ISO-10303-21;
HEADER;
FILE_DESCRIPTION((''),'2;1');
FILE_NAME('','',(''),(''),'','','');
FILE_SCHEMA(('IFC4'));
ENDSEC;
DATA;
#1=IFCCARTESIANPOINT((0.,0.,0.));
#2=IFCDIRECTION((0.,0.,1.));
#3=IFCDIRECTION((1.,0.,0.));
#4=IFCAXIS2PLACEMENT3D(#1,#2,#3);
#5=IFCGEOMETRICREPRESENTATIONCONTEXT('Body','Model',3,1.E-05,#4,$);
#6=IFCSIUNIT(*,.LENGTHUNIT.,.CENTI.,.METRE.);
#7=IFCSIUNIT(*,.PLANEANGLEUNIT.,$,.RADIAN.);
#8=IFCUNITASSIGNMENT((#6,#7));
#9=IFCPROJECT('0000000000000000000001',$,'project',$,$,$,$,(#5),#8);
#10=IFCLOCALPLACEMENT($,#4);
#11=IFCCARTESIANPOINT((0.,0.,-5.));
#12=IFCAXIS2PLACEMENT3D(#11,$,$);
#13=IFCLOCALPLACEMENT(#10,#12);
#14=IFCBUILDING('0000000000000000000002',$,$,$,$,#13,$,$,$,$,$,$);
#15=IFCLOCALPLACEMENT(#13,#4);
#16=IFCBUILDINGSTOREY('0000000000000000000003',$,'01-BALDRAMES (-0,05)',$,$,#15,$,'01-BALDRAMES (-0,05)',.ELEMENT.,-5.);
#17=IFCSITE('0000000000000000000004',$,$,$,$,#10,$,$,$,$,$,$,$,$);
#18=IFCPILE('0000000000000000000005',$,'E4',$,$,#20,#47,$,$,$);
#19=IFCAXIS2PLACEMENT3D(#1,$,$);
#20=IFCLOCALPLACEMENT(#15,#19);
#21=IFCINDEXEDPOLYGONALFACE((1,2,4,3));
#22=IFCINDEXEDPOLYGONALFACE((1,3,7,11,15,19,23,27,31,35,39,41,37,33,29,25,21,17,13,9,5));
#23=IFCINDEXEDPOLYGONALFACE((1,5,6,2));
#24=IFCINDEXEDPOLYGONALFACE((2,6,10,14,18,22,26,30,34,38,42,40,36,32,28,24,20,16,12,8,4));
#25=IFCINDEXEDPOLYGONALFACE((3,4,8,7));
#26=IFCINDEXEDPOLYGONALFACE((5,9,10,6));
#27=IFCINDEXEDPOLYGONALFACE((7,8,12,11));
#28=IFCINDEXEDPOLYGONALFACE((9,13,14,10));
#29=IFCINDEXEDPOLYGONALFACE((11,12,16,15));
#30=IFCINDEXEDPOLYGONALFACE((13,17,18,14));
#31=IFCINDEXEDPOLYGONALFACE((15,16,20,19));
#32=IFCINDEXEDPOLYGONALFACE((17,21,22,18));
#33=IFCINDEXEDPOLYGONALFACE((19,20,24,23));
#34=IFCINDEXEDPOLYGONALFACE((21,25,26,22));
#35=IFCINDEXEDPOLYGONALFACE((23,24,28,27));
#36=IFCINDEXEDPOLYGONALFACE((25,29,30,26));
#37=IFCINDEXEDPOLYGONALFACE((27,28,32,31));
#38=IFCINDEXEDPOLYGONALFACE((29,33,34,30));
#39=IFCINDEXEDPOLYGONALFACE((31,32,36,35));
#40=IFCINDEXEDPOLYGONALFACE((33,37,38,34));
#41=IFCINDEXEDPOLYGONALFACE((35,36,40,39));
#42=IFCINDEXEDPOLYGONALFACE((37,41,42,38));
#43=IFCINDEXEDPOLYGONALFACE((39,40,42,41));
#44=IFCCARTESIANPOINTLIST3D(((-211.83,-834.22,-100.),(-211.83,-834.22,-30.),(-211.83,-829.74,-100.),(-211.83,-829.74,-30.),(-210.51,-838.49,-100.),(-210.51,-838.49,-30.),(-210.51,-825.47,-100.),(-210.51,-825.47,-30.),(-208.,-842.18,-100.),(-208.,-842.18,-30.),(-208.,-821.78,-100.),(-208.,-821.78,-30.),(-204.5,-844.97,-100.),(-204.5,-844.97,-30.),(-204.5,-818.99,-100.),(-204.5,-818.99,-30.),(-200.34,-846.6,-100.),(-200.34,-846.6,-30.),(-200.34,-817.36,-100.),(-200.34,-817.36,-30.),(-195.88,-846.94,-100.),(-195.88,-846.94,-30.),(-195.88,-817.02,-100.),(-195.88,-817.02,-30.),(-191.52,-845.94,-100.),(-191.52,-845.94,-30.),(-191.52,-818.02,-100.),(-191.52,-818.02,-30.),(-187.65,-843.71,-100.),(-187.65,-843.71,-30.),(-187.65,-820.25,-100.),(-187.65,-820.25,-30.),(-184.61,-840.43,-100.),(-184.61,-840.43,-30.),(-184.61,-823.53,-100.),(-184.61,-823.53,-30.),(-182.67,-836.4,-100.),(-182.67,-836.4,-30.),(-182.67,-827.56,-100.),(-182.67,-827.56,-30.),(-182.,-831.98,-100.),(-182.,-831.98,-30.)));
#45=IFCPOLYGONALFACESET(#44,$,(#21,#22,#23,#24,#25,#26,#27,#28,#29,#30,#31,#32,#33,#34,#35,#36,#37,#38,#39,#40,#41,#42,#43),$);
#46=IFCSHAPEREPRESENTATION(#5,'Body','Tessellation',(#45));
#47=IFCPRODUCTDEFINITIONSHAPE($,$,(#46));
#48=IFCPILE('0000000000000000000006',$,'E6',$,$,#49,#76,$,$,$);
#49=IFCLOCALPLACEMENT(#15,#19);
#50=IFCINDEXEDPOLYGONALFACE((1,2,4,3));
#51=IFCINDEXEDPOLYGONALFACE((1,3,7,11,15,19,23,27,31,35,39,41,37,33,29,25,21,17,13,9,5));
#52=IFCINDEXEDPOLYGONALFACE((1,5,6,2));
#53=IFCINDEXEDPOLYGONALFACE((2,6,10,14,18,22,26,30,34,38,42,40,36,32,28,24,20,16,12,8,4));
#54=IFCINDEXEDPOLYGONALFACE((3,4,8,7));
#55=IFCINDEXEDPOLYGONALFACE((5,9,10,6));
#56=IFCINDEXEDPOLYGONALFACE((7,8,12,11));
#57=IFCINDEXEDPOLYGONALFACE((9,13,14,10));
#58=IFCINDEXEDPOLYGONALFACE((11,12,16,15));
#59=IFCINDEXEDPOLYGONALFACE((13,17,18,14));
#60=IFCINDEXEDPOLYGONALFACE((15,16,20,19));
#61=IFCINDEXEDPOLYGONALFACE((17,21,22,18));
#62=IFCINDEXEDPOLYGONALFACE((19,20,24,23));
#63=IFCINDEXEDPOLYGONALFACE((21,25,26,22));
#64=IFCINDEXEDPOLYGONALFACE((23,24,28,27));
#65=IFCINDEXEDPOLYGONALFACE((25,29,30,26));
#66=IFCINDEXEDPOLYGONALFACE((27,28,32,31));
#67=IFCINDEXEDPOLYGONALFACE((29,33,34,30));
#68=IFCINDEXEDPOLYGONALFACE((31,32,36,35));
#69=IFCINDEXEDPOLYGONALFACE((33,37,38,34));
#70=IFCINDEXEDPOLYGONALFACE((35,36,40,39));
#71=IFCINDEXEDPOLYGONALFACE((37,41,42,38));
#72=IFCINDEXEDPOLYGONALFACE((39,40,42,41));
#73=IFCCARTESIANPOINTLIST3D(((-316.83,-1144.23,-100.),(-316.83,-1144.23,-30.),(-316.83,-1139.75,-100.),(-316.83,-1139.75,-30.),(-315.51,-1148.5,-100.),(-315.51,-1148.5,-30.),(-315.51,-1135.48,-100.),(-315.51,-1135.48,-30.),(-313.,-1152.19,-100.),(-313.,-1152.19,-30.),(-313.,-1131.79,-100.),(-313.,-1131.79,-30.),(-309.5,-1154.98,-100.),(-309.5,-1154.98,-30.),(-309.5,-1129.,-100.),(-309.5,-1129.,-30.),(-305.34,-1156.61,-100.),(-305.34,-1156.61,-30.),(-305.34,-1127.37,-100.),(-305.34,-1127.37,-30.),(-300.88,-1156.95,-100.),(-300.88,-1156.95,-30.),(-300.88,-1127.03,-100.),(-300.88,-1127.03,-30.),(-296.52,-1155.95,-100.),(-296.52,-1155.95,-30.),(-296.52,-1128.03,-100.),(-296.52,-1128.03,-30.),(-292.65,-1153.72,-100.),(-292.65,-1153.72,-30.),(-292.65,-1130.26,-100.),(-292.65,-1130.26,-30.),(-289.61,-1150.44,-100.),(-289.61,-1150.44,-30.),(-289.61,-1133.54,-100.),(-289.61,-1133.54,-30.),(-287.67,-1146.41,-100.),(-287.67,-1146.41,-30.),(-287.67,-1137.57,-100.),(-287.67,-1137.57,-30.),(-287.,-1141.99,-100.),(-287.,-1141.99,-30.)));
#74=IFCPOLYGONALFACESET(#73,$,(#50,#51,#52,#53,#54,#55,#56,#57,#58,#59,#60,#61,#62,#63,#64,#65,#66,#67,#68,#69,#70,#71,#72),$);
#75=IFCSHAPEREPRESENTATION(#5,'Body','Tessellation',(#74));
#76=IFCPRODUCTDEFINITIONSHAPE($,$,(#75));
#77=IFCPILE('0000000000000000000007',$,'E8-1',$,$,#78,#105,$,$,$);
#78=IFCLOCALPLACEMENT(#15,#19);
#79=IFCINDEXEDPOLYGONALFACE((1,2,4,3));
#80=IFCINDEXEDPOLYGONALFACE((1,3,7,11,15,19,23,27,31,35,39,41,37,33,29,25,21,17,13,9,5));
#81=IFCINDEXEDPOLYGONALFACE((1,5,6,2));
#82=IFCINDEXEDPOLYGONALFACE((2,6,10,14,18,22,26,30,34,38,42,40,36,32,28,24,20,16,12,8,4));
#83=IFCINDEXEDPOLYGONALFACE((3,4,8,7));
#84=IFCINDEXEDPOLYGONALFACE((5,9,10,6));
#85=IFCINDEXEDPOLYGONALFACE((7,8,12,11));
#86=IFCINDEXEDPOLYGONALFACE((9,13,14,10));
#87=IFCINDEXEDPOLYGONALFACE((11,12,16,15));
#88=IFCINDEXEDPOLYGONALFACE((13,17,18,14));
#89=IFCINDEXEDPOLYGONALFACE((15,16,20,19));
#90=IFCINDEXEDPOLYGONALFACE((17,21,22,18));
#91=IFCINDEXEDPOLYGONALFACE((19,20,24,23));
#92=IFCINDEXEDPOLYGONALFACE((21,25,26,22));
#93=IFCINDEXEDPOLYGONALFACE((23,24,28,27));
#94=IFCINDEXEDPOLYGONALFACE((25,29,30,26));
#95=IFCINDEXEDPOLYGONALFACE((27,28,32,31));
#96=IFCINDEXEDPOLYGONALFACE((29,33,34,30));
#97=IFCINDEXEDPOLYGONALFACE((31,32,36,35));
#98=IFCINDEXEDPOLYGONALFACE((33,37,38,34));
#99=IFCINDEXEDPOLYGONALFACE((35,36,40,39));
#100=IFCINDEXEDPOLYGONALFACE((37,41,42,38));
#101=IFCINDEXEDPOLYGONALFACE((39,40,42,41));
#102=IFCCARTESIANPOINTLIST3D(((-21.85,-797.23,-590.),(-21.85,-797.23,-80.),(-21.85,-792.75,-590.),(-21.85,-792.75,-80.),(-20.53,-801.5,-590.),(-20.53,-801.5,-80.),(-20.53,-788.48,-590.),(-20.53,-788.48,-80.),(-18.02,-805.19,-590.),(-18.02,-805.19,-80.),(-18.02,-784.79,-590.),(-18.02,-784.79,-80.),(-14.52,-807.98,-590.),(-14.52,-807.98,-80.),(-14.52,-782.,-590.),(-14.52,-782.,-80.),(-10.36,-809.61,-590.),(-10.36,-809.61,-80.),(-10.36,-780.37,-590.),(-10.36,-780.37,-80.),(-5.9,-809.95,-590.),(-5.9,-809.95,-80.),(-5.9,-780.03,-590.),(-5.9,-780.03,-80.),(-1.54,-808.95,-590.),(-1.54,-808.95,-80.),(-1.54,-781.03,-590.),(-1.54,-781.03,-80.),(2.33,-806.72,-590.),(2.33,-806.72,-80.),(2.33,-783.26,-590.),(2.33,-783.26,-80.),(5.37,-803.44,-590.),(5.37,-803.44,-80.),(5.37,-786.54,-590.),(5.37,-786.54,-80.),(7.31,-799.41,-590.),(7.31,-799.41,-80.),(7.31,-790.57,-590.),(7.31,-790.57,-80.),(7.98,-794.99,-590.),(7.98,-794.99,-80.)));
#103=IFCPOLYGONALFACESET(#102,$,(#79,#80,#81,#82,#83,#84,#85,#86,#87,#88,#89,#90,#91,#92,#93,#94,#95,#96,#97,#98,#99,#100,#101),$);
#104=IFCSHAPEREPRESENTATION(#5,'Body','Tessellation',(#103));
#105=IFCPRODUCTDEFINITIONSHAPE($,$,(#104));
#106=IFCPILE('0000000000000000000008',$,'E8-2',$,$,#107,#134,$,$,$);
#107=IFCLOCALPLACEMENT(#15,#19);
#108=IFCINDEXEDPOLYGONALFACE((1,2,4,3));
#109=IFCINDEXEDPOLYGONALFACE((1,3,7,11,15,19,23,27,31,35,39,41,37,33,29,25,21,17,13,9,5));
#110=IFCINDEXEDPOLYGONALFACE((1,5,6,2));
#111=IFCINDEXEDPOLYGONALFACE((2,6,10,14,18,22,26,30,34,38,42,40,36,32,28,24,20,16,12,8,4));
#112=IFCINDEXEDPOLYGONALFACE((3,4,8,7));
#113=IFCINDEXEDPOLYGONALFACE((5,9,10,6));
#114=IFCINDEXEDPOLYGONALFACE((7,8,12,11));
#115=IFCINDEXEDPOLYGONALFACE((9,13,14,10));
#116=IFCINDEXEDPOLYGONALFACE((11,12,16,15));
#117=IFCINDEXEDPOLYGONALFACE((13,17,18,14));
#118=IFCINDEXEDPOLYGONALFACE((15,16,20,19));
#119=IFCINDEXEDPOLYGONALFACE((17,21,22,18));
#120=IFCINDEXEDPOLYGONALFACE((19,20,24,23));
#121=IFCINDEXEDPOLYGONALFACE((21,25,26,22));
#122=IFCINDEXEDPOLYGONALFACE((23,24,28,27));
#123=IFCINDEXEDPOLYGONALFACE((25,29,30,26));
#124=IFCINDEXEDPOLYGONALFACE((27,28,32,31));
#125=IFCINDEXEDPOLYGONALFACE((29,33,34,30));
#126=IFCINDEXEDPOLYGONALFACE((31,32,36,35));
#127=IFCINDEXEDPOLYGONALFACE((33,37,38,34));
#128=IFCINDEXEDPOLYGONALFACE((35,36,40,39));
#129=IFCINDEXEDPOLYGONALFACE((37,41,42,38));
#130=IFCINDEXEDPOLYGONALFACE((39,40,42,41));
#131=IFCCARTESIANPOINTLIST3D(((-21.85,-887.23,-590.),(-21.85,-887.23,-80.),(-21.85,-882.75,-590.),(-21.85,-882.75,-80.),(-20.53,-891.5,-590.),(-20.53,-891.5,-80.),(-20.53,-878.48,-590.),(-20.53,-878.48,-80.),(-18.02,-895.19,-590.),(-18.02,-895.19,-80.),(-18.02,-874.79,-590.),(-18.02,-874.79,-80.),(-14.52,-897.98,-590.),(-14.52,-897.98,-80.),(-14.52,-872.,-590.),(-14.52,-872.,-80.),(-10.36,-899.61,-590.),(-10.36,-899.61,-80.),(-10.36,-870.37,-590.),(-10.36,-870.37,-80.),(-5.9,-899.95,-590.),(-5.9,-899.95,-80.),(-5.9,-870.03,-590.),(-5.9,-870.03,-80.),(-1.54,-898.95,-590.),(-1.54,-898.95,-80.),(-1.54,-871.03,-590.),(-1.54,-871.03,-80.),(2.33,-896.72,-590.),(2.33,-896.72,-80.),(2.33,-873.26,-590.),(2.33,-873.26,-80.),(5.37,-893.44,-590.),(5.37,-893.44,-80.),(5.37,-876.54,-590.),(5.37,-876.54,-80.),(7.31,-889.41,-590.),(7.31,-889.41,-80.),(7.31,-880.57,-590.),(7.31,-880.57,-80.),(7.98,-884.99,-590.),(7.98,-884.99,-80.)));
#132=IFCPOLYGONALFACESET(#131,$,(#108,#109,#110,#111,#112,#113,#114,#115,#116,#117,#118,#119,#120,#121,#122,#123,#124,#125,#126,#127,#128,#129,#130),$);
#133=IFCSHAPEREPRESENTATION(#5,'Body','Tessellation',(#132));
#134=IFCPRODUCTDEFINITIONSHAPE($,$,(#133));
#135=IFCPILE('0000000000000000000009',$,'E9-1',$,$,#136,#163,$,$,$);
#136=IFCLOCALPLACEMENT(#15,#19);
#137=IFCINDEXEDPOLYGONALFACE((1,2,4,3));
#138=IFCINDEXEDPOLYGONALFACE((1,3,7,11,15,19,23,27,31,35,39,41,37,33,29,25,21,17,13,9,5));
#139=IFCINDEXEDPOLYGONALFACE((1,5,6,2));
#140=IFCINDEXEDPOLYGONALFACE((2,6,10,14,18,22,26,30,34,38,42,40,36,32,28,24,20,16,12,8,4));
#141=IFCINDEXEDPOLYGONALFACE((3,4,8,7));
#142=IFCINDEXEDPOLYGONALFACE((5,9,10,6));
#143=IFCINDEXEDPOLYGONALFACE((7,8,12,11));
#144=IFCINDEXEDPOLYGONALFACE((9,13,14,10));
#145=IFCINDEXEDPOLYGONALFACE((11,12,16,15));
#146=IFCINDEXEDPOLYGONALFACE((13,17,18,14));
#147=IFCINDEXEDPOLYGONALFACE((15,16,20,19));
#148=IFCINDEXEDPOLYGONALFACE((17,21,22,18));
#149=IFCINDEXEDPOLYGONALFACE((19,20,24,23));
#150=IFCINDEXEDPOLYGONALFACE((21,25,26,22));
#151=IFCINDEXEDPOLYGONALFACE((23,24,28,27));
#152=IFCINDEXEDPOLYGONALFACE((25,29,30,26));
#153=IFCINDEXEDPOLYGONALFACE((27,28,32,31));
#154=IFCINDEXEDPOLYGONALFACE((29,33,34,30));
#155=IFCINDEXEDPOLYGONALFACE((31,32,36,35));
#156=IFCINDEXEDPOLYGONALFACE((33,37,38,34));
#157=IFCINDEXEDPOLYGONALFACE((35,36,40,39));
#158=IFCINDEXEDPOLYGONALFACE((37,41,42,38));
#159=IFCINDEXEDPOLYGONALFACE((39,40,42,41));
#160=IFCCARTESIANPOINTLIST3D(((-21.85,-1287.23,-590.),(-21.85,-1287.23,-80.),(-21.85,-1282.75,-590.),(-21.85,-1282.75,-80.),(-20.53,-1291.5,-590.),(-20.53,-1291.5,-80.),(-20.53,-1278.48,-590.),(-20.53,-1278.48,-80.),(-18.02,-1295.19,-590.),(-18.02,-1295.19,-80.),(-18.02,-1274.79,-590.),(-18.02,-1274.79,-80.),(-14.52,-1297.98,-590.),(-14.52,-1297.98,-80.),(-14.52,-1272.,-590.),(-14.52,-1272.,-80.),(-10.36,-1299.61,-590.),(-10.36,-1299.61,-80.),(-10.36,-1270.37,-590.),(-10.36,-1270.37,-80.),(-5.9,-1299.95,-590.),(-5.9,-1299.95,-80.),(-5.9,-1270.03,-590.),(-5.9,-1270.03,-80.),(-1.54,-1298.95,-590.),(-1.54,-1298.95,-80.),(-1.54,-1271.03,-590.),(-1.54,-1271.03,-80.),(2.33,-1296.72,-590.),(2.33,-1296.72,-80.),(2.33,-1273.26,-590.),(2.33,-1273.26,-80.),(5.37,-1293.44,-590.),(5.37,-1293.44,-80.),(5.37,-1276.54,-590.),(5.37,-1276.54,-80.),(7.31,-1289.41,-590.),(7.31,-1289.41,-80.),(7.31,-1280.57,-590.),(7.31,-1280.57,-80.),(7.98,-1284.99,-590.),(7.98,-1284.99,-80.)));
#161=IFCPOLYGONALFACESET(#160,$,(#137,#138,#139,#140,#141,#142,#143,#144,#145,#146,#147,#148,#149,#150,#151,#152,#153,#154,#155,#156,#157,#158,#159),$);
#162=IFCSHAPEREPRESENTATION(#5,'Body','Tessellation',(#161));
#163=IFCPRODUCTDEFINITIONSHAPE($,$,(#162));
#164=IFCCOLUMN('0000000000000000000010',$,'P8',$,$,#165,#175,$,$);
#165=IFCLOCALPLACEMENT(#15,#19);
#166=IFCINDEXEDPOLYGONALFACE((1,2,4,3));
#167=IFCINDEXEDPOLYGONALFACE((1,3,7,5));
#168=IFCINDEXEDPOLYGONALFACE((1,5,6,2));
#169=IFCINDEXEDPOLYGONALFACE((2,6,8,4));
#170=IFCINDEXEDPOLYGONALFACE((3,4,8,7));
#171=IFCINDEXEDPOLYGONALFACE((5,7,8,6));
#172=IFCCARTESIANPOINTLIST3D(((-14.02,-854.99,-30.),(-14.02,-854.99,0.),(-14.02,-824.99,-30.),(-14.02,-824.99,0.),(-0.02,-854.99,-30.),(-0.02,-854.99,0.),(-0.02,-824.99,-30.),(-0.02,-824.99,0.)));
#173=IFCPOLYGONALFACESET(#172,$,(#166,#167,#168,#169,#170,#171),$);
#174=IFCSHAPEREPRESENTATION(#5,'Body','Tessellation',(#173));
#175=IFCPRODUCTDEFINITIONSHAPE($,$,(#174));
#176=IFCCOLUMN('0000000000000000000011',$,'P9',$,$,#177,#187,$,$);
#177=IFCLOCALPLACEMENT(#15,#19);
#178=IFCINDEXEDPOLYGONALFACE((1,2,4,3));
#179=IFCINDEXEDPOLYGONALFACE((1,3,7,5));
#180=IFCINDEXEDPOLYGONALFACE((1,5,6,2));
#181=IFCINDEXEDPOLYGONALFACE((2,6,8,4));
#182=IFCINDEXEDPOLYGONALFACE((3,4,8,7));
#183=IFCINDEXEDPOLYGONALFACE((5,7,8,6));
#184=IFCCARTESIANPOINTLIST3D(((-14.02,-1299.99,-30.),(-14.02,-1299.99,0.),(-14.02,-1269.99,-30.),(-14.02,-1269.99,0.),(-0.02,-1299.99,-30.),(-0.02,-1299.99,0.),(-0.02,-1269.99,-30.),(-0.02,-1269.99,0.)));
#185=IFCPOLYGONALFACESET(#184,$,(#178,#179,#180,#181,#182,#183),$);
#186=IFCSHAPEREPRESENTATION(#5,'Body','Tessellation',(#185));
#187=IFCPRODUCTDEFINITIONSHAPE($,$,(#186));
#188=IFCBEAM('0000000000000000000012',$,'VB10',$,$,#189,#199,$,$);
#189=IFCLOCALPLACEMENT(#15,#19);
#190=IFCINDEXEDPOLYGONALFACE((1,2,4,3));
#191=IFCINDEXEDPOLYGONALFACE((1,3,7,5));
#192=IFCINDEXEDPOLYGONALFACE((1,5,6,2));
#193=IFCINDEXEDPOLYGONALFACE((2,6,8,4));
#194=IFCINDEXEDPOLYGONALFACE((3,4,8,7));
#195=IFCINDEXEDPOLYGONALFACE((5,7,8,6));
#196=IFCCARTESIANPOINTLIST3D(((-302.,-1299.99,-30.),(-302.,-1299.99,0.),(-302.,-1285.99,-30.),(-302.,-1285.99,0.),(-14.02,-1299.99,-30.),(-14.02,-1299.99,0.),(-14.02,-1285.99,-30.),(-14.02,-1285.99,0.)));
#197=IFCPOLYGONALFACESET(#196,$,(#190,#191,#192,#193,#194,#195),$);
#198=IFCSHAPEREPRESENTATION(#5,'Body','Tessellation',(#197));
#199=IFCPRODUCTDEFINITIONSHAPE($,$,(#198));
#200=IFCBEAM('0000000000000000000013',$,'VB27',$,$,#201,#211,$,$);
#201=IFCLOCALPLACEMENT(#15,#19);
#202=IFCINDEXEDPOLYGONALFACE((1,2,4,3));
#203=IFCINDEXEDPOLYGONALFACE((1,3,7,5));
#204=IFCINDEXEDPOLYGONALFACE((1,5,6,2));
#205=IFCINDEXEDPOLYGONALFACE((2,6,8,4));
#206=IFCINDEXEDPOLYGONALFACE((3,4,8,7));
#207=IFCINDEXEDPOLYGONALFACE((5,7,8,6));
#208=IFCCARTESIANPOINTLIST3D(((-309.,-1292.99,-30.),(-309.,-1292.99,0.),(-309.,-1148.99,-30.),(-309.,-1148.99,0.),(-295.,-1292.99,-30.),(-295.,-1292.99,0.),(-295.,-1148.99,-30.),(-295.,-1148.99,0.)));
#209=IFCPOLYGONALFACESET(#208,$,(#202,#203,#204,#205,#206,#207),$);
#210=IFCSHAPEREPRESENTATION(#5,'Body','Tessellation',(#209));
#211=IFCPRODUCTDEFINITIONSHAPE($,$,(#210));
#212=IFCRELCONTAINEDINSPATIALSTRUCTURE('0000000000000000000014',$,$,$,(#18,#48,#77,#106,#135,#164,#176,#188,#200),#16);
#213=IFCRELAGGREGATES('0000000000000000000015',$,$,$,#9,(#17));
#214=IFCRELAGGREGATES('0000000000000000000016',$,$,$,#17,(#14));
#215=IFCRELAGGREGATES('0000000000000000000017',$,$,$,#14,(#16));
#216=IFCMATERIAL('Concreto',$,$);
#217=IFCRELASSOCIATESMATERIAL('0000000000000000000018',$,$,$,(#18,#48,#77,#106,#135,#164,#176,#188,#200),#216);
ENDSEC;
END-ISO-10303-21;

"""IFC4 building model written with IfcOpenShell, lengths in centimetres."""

from ifc_helpers import new_model, si_unit, frame, origin_with_axes, origin_2d_with_axis, place, context, project, spatial, rectangle, circle, extrude, material, element, save


model = new_model("IFC4")

# Units and contexts
model_context = context("Model", 3, precision=1e-05, world=origin_with_axes(), identifier="Body")
ifc_project = project(units=[si_unit("LENGTHUNIT", "METRE", prefix="CENTI"), si_unit("PLANEANGLEUNIT", "RADIAN")], contexts=[model_context])

# Site, building, storey
site_placement = place(None, origin_with_axes())
site = spatial("IfcSite", under=ifc_project, at=site_placement)
building_placement = place(site_placement, frame((0.0, 0.0, -5.0)))
building = spatial("IfcBuilding", under=site, at=building_placement)
storey_placement = place(building_placement, origin_with_axes())
storey = spatial("IfcBuildingStorey", under=building, at=storey_placement, Name="01-BALDRAMES (-0,05)", LongName="01-BALDRAMES (-0,05)", CompositionType="ELEMENT", Elevation=-5.0)

# Piles
ifc_material = material(Name="Concreto")
for number, where, z_axis, x_axis, name in (
    (1, (-197.0, -831.98, -30.0), (0.0, 0.0, 1.0), (1.0, 0.0, 0.0), "E4"),
    (2, (-302.0, -1141.99, -30.0), (0.0, 0.0, 1.0), (1.0, 0.0, 0.0), "E6"),
):
    element("IfcPile", number, at=place(storey_placement, frame(where, z_axis=z_axis, x_axis=x_axis)), inside=storey, material=ifc_material, Name=name, context=model_context, shape_type="SolidModel", body=[
        extrude(circle(Radius=15.0, at=origin_2d_with_axis()), frame((0.0, 0.0, -70.0), z_axis=(0.0, 0.0, 1.0), x_axis=(1.0, 0.0, 0.0)), (0.0, 0.0, 1.0), 70.0),
    ])
for number, where, z_axis, x_axis, name in (
    (3, (-7.02, -794.99, -80.0), (0.0, 0.0, 1.0), (1.0, 0.0, 0.0), "E8-1"),
    (4, (-7.02, -884.99, -80.0), (0.0, 0.0, 1.0), (1.0, 0.0, 0.0), "E8-2"),
    (5, (-7.02, -1284.99, -80.0), (0.0, 0.0, 1.0), (1.0, 0.0, 0.0), "E9-1"),
):
    element("IfcPile", number, at=place(storey_placement, frame(where, z_axis=z_axis, x_axis=x_axis)), inside=storey, material=ifc_material, Name=name, context=model_context, shape_type="SweptSolid", body=[
        extrude(circle(Radius=15.0, at=origin_2d_with_axis()), frame((0.0, 0.0, -510.0), z_axis=(0.0, 0.0, 1.0), x_axis=(1.0, 0.0, 0.0)), (0.0, 0.0, 1.0), 510.0),
    ])

# Columns
for number, where, z_axis, x_axis, name in (
    (6, (-7.02, -839.99, 0.0), (0.0, 0.0, 1.0), (1.0, 0.0, 0.0), "P8"),
    (7, (-7.02, -1284.99, 0.0), (0.0, 0.0, 1.0), (1.0, 0.0, 0.0), "P9"),
):
    element("IfcColumn", number, at=place(storey_placement, frame(where, z_axis=z_axis, x_axis=x_axis)), inside=storey, material=ifc_material, Name=name, context=model_context, shape_type="SolidModel", body=[
        extrude(rectangle(XDim=14.0, YDim=30.0, at=origin_2d_with_axis()), origin_with_axes(), (0.0, 0.0, -1.0), 30.0),
    ])

# Beams
beam_1_placement = place(storey_placement, frame((-158.01, -1292.99, 0.0), z_axis=(0.0, 0.0, 1.0), x_axis=(1.0, 0.0, 0.0)))
element("IfcBeam", 8, at=beam_1_placement, inside=storey, material=ifc_material, Name="VB10", context=model_context, shape_type="SolidModel", body=[
    extrude(rectangle(XDim=14.0, YDim=30.0, at=origin_2d_with_axis()), frame((-143.99, 0.0, -15.0), z_axis=(1.0, 0.0, 0.0), x_axis=(0.0, -1.0, 0.0)), (0.0, 0.0, 1.0), 287.98),
])
beam_2_placement = place(storey_placement, frame((-302.0, -1220.99, 0.0), z_axis=(0.0, 0.0, 1.0), x_axis=(1.0, 0.0, 0.0)))
element("IfcBeam", 9, at=beam_2_placement, inside=storey, material=ifc_material, Name="VB27", context=model_context, shape_type="SolidModel", body=[
    extrude(rectangle(XDim=14.0, YDim=30.0, at=origin_2d_with_axis()), frame((0.0, -72.0, -15.0), z_axis=(0.0, 1.0, 0.0), x_axis=(1.0, 0.0, 0.0)), (0.0, 0.0, 1.0), 144.0),
])

save(model, "model.ifc")
